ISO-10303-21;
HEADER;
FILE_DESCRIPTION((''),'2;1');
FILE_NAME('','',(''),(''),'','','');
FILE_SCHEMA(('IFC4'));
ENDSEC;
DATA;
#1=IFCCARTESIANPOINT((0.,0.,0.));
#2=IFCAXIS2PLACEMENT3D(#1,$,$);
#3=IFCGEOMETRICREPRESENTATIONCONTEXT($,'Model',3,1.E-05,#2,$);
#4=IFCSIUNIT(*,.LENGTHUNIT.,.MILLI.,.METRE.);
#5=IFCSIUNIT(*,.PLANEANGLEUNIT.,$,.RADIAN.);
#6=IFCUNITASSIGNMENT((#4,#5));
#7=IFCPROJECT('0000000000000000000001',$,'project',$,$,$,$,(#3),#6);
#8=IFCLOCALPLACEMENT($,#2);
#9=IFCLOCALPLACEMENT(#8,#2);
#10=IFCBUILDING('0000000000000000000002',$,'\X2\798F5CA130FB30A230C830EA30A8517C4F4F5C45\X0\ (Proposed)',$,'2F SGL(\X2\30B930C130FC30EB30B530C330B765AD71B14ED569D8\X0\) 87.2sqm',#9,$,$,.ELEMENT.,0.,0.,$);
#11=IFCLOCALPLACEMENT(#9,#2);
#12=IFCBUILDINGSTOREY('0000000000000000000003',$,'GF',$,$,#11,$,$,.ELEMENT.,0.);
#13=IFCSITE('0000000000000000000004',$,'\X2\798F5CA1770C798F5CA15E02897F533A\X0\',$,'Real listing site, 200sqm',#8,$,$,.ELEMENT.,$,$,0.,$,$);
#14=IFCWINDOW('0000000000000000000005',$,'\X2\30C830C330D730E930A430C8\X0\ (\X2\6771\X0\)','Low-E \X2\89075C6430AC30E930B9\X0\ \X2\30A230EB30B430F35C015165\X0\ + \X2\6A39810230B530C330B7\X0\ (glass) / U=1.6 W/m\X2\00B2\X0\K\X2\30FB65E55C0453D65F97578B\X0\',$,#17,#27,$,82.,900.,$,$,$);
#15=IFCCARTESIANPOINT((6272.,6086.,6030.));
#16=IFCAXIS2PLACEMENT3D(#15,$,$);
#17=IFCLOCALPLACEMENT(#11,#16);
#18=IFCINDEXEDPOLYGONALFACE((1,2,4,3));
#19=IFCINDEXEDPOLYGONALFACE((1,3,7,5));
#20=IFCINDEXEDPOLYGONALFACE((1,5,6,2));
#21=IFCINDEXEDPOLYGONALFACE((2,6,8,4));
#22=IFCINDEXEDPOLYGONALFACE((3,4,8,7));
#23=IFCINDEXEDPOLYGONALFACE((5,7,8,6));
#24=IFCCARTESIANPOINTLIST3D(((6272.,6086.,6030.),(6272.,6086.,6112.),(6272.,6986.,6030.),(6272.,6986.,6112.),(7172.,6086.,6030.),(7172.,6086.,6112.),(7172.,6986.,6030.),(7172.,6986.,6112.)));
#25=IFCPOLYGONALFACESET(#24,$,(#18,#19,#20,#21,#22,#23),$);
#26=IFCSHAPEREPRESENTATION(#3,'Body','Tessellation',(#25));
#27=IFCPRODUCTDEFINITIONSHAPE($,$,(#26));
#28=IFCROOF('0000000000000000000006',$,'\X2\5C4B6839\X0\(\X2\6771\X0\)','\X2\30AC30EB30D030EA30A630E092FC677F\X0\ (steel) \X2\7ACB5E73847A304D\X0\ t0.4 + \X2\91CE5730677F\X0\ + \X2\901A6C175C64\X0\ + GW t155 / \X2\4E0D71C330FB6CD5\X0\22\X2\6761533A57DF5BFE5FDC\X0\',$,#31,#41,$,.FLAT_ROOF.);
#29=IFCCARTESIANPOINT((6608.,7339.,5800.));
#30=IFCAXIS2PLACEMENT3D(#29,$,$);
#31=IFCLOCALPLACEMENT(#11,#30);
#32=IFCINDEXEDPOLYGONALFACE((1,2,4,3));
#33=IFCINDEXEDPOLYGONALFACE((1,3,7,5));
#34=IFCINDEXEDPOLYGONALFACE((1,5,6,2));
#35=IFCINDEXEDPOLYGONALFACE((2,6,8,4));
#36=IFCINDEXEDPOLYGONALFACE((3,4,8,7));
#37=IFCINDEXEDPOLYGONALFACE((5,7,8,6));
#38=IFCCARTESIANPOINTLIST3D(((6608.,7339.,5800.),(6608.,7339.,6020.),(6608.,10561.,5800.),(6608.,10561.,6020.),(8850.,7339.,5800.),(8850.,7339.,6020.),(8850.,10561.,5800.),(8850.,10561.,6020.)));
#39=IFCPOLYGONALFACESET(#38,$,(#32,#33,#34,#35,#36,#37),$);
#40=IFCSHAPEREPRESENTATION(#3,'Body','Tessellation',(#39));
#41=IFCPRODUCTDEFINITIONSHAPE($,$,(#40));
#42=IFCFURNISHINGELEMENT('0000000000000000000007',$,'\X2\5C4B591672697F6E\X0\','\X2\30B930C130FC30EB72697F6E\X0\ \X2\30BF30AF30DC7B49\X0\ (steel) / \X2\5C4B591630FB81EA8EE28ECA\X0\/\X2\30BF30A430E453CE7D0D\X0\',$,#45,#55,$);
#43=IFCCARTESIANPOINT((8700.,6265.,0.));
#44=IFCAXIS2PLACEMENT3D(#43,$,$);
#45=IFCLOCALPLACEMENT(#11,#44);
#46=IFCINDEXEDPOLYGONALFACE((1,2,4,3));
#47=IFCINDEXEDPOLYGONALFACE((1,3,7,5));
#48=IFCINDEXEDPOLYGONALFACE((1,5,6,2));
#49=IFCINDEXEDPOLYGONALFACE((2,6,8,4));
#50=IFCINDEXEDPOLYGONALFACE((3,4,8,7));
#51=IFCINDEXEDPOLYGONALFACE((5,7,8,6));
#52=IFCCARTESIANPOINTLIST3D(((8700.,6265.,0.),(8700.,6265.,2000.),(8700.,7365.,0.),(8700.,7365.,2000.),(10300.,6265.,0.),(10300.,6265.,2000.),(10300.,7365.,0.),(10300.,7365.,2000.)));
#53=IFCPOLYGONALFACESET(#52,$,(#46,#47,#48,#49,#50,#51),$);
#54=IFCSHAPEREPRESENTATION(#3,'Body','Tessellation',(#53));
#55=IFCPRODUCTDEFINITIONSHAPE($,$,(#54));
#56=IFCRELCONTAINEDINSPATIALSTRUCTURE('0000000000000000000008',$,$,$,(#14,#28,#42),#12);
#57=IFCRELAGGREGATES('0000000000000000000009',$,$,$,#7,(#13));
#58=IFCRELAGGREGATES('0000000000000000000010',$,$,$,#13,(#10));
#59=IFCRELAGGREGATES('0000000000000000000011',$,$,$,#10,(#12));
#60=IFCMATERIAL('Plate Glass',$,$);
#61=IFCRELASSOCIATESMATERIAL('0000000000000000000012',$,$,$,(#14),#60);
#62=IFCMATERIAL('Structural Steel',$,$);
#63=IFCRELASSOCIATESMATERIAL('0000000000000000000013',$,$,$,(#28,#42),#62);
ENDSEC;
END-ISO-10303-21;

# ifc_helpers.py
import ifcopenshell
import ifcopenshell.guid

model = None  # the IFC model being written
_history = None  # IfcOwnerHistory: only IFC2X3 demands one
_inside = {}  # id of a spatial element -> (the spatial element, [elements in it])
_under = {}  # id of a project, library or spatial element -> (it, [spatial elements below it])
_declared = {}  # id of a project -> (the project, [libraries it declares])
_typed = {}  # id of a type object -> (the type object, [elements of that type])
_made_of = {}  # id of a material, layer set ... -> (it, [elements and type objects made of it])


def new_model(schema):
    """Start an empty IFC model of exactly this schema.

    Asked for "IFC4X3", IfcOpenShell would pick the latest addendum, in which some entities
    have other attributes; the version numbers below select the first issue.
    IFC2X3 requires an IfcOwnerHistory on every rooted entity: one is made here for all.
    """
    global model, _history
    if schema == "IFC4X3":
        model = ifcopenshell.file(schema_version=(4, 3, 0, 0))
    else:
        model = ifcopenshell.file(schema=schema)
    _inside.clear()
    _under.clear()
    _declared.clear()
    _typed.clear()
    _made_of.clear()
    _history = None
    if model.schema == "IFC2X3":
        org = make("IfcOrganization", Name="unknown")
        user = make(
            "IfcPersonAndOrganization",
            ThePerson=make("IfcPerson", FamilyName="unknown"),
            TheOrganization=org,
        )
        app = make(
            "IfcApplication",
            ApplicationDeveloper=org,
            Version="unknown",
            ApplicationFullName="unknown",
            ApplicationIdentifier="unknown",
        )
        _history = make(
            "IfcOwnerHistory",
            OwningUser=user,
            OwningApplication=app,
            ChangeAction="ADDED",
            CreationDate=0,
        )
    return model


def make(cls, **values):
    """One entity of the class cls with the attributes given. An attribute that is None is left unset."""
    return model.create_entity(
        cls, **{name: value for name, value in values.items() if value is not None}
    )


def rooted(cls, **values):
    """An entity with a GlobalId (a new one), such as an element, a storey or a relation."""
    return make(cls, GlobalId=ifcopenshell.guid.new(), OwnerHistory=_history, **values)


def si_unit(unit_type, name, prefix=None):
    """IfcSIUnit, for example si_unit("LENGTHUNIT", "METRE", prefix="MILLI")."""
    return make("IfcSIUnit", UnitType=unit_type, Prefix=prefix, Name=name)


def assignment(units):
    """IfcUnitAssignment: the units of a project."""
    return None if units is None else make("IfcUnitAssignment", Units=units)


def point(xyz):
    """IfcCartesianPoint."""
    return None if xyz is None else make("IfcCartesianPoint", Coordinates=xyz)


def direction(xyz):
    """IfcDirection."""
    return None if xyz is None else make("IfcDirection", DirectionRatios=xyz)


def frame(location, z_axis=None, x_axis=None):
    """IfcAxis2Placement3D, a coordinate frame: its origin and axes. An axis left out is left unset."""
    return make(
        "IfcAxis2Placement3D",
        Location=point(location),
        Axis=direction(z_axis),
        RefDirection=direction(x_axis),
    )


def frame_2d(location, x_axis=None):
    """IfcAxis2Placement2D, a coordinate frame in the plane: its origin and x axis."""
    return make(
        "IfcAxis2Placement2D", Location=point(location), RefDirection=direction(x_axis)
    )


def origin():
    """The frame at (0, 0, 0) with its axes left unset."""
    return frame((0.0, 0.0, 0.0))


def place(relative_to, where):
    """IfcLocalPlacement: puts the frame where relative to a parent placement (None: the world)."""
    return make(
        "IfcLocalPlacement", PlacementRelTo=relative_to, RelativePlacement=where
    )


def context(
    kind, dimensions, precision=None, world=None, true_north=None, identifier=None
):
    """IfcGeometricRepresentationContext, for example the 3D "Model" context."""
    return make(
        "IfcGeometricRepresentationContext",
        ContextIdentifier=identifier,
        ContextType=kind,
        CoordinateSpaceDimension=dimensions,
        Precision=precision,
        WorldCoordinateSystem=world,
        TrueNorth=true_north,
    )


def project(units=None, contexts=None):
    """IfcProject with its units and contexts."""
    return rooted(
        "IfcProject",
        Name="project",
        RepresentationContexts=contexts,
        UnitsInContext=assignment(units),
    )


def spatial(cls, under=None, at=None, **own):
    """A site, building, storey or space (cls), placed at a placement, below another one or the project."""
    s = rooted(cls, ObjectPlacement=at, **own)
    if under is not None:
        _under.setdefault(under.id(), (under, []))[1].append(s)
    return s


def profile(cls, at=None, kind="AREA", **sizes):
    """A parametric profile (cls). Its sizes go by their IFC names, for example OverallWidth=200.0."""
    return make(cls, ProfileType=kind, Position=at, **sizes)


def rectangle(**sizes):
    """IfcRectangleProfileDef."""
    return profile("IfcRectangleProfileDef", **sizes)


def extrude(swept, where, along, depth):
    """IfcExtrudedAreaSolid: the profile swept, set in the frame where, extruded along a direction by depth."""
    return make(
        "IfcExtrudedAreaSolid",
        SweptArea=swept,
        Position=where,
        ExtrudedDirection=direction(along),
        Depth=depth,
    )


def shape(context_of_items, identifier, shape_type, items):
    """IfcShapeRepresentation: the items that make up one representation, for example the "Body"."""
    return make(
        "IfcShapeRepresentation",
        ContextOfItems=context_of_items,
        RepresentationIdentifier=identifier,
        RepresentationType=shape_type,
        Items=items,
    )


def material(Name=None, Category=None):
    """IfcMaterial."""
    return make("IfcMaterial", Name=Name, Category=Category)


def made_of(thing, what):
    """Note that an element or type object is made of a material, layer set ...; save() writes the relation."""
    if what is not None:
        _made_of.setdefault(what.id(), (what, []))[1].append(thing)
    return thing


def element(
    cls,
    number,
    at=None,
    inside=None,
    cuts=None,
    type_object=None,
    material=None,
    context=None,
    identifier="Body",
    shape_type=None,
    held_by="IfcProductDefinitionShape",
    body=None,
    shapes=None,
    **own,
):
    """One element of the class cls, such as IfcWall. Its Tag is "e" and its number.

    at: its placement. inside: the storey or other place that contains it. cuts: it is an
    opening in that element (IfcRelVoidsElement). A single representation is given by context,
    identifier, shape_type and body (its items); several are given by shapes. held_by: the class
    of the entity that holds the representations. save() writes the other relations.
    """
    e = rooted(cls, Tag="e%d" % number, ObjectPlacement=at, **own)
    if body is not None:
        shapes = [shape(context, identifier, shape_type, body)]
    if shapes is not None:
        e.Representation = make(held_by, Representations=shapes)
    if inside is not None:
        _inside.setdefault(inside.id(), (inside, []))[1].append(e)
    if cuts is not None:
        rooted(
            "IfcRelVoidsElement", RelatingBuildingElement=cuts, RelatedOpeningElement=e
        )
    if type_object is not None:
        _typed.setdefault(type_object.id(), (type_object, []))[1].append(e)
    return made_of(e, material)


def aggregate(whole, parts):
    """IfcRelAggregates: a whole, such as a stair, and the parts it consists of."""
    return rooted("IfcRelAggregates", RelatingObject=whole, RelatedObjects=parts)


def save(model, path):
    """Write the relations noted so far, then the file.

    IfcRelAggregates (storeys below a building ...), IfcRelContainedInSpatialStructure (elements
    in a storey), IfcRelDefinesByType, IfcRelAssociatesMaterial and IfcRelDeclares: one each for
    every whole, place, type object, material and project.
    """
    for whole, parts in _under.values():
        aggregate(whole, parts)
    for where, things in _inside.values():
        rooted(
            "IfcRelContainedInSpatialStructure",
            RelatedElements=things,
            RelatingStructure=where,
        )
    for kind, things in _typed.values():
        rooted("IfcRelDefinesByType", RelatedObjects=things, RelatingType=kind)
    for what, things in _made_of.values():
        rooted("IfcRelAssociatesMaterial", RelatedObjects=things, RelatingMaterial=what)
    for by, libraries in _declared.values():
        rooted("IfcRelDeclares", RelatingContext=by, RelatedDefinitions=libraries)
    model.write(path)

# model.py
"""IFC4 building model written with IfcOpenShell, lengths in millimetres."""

from ifc_helpers import new_model, si_unit, frame, frame_2d, origin, place, context, project, spatial, rectangle, extrude, material, element, save


model = new_model("IFC4")

# Units and contexts
model_context = context("Model", 3, precision=1e-05, world=origin())
ifc_project = project(units=[si_unit("LENGTHUNIT", "METRE", prefix="MILLI"), si_unit("PLANEANGLEUNIT", "RADIAN")], contexts=[model_context])

# Site, building, storey
site_placement = place(None, origin())
site = spatial("IfcSite", under=ifc_project, at=site_placement, Name="福岡県福岡市西区", ObjectType="Real listing site, 200sqm", CompositionType="ELEMENT", RefElevation=0.0)
building_placement = place(site_placement, origin())
building = spatial("IfcBuilding", under=site, at=building_placement, Name="福岡・アトリエ兼住居 (Proposed)", ObjectType="2F SGL(スチールサッシ断熱仕様) 87.2sqm", CompositionType="ELEMENT", ElevationOfRefHeight=0.0, ElevationOfTerrain=0.0)
storey_placement = place(building_placement, origin())
storey = spatial("IfcBuildingStorey", under=building, at=storey_placement, Name="GF", CompositionType="ELEMENT", Elevation=0.0)

# Shared definitions
ifc_material_1 = material(Name="Plate Glass")

# Window
window_1_placement = place(storey_placement, frame((6272.0, 6086.0, 6030.0)))
element("IfcWindow", 1, at=window_1_placement, inside=storey, material=ifc_material_1, Name="トップライト (東)", Description="Low-E 複層ガラス アルゴン封入 + 樹脂サッシ (glass) / U=1.6 W/m²K・日射取得型", OverallHeight=82.0, OverallWidth=900.0, context=model_context, shape_type="SweptSolid", body=[
    extrude(rectangle(XDim=900.0, YDim=900.0, at=frame_2d((450.0, 450.0))), frame((6272.0, 6086.0, 6030.0)), (0.0, 0.0, 1.0), 82.0),
])

# Roof
ifc_material_2 = material(Name="Structural Steel")
for number, where, name in (
    (2, (6608.0, 7339.0, 5800.0), "屋根(東)"),
):
    element("IfcRoof", number, at=place(storey_placement, frame(where)), inside=storey, material=ifc_material_2, Name=name, Description="ガルバリウム鋼板 (steel) 立平葺き t0.4 + 野地板 + 通気層 + GW t155 / 不燃・法22条区域対応", PredefinedType="FLAT_ROOF", context=model_context, shape_type="SweptSolid", body=[
        extrude(rectangle(XDim=2242.0, YDim=3222.0, at=frame_2d((1121.0, 1611.0))), frame((6608.0, 7339.0, 5800.0)), (0.0, 0.0, 1.0), 220.0),
    ])

# Furnishing element
furnishing_placement = place(storey_placement, frame((8700.0, 6265.0, 0.0)))
element("IfcFurnishingElement", 3, at=furnishing_placement, inside=storey, material=ifc_material_2, Name="屋外物置", Description="スチール物置 タクボ等 (steel) / 屋外・自転車/タイヤ収納", context=model_context, shape_type="SweptSolid", body=[
    extrude(rectangle(XDim=1600.0, YDim=1100.0, at=frame_2d((800.0, 550.0))), frame((8700.0, 6265.0, 0.0)), (0.0, 0.0, 1.0), 2000.0),
])

save(model, "model.ifc")
